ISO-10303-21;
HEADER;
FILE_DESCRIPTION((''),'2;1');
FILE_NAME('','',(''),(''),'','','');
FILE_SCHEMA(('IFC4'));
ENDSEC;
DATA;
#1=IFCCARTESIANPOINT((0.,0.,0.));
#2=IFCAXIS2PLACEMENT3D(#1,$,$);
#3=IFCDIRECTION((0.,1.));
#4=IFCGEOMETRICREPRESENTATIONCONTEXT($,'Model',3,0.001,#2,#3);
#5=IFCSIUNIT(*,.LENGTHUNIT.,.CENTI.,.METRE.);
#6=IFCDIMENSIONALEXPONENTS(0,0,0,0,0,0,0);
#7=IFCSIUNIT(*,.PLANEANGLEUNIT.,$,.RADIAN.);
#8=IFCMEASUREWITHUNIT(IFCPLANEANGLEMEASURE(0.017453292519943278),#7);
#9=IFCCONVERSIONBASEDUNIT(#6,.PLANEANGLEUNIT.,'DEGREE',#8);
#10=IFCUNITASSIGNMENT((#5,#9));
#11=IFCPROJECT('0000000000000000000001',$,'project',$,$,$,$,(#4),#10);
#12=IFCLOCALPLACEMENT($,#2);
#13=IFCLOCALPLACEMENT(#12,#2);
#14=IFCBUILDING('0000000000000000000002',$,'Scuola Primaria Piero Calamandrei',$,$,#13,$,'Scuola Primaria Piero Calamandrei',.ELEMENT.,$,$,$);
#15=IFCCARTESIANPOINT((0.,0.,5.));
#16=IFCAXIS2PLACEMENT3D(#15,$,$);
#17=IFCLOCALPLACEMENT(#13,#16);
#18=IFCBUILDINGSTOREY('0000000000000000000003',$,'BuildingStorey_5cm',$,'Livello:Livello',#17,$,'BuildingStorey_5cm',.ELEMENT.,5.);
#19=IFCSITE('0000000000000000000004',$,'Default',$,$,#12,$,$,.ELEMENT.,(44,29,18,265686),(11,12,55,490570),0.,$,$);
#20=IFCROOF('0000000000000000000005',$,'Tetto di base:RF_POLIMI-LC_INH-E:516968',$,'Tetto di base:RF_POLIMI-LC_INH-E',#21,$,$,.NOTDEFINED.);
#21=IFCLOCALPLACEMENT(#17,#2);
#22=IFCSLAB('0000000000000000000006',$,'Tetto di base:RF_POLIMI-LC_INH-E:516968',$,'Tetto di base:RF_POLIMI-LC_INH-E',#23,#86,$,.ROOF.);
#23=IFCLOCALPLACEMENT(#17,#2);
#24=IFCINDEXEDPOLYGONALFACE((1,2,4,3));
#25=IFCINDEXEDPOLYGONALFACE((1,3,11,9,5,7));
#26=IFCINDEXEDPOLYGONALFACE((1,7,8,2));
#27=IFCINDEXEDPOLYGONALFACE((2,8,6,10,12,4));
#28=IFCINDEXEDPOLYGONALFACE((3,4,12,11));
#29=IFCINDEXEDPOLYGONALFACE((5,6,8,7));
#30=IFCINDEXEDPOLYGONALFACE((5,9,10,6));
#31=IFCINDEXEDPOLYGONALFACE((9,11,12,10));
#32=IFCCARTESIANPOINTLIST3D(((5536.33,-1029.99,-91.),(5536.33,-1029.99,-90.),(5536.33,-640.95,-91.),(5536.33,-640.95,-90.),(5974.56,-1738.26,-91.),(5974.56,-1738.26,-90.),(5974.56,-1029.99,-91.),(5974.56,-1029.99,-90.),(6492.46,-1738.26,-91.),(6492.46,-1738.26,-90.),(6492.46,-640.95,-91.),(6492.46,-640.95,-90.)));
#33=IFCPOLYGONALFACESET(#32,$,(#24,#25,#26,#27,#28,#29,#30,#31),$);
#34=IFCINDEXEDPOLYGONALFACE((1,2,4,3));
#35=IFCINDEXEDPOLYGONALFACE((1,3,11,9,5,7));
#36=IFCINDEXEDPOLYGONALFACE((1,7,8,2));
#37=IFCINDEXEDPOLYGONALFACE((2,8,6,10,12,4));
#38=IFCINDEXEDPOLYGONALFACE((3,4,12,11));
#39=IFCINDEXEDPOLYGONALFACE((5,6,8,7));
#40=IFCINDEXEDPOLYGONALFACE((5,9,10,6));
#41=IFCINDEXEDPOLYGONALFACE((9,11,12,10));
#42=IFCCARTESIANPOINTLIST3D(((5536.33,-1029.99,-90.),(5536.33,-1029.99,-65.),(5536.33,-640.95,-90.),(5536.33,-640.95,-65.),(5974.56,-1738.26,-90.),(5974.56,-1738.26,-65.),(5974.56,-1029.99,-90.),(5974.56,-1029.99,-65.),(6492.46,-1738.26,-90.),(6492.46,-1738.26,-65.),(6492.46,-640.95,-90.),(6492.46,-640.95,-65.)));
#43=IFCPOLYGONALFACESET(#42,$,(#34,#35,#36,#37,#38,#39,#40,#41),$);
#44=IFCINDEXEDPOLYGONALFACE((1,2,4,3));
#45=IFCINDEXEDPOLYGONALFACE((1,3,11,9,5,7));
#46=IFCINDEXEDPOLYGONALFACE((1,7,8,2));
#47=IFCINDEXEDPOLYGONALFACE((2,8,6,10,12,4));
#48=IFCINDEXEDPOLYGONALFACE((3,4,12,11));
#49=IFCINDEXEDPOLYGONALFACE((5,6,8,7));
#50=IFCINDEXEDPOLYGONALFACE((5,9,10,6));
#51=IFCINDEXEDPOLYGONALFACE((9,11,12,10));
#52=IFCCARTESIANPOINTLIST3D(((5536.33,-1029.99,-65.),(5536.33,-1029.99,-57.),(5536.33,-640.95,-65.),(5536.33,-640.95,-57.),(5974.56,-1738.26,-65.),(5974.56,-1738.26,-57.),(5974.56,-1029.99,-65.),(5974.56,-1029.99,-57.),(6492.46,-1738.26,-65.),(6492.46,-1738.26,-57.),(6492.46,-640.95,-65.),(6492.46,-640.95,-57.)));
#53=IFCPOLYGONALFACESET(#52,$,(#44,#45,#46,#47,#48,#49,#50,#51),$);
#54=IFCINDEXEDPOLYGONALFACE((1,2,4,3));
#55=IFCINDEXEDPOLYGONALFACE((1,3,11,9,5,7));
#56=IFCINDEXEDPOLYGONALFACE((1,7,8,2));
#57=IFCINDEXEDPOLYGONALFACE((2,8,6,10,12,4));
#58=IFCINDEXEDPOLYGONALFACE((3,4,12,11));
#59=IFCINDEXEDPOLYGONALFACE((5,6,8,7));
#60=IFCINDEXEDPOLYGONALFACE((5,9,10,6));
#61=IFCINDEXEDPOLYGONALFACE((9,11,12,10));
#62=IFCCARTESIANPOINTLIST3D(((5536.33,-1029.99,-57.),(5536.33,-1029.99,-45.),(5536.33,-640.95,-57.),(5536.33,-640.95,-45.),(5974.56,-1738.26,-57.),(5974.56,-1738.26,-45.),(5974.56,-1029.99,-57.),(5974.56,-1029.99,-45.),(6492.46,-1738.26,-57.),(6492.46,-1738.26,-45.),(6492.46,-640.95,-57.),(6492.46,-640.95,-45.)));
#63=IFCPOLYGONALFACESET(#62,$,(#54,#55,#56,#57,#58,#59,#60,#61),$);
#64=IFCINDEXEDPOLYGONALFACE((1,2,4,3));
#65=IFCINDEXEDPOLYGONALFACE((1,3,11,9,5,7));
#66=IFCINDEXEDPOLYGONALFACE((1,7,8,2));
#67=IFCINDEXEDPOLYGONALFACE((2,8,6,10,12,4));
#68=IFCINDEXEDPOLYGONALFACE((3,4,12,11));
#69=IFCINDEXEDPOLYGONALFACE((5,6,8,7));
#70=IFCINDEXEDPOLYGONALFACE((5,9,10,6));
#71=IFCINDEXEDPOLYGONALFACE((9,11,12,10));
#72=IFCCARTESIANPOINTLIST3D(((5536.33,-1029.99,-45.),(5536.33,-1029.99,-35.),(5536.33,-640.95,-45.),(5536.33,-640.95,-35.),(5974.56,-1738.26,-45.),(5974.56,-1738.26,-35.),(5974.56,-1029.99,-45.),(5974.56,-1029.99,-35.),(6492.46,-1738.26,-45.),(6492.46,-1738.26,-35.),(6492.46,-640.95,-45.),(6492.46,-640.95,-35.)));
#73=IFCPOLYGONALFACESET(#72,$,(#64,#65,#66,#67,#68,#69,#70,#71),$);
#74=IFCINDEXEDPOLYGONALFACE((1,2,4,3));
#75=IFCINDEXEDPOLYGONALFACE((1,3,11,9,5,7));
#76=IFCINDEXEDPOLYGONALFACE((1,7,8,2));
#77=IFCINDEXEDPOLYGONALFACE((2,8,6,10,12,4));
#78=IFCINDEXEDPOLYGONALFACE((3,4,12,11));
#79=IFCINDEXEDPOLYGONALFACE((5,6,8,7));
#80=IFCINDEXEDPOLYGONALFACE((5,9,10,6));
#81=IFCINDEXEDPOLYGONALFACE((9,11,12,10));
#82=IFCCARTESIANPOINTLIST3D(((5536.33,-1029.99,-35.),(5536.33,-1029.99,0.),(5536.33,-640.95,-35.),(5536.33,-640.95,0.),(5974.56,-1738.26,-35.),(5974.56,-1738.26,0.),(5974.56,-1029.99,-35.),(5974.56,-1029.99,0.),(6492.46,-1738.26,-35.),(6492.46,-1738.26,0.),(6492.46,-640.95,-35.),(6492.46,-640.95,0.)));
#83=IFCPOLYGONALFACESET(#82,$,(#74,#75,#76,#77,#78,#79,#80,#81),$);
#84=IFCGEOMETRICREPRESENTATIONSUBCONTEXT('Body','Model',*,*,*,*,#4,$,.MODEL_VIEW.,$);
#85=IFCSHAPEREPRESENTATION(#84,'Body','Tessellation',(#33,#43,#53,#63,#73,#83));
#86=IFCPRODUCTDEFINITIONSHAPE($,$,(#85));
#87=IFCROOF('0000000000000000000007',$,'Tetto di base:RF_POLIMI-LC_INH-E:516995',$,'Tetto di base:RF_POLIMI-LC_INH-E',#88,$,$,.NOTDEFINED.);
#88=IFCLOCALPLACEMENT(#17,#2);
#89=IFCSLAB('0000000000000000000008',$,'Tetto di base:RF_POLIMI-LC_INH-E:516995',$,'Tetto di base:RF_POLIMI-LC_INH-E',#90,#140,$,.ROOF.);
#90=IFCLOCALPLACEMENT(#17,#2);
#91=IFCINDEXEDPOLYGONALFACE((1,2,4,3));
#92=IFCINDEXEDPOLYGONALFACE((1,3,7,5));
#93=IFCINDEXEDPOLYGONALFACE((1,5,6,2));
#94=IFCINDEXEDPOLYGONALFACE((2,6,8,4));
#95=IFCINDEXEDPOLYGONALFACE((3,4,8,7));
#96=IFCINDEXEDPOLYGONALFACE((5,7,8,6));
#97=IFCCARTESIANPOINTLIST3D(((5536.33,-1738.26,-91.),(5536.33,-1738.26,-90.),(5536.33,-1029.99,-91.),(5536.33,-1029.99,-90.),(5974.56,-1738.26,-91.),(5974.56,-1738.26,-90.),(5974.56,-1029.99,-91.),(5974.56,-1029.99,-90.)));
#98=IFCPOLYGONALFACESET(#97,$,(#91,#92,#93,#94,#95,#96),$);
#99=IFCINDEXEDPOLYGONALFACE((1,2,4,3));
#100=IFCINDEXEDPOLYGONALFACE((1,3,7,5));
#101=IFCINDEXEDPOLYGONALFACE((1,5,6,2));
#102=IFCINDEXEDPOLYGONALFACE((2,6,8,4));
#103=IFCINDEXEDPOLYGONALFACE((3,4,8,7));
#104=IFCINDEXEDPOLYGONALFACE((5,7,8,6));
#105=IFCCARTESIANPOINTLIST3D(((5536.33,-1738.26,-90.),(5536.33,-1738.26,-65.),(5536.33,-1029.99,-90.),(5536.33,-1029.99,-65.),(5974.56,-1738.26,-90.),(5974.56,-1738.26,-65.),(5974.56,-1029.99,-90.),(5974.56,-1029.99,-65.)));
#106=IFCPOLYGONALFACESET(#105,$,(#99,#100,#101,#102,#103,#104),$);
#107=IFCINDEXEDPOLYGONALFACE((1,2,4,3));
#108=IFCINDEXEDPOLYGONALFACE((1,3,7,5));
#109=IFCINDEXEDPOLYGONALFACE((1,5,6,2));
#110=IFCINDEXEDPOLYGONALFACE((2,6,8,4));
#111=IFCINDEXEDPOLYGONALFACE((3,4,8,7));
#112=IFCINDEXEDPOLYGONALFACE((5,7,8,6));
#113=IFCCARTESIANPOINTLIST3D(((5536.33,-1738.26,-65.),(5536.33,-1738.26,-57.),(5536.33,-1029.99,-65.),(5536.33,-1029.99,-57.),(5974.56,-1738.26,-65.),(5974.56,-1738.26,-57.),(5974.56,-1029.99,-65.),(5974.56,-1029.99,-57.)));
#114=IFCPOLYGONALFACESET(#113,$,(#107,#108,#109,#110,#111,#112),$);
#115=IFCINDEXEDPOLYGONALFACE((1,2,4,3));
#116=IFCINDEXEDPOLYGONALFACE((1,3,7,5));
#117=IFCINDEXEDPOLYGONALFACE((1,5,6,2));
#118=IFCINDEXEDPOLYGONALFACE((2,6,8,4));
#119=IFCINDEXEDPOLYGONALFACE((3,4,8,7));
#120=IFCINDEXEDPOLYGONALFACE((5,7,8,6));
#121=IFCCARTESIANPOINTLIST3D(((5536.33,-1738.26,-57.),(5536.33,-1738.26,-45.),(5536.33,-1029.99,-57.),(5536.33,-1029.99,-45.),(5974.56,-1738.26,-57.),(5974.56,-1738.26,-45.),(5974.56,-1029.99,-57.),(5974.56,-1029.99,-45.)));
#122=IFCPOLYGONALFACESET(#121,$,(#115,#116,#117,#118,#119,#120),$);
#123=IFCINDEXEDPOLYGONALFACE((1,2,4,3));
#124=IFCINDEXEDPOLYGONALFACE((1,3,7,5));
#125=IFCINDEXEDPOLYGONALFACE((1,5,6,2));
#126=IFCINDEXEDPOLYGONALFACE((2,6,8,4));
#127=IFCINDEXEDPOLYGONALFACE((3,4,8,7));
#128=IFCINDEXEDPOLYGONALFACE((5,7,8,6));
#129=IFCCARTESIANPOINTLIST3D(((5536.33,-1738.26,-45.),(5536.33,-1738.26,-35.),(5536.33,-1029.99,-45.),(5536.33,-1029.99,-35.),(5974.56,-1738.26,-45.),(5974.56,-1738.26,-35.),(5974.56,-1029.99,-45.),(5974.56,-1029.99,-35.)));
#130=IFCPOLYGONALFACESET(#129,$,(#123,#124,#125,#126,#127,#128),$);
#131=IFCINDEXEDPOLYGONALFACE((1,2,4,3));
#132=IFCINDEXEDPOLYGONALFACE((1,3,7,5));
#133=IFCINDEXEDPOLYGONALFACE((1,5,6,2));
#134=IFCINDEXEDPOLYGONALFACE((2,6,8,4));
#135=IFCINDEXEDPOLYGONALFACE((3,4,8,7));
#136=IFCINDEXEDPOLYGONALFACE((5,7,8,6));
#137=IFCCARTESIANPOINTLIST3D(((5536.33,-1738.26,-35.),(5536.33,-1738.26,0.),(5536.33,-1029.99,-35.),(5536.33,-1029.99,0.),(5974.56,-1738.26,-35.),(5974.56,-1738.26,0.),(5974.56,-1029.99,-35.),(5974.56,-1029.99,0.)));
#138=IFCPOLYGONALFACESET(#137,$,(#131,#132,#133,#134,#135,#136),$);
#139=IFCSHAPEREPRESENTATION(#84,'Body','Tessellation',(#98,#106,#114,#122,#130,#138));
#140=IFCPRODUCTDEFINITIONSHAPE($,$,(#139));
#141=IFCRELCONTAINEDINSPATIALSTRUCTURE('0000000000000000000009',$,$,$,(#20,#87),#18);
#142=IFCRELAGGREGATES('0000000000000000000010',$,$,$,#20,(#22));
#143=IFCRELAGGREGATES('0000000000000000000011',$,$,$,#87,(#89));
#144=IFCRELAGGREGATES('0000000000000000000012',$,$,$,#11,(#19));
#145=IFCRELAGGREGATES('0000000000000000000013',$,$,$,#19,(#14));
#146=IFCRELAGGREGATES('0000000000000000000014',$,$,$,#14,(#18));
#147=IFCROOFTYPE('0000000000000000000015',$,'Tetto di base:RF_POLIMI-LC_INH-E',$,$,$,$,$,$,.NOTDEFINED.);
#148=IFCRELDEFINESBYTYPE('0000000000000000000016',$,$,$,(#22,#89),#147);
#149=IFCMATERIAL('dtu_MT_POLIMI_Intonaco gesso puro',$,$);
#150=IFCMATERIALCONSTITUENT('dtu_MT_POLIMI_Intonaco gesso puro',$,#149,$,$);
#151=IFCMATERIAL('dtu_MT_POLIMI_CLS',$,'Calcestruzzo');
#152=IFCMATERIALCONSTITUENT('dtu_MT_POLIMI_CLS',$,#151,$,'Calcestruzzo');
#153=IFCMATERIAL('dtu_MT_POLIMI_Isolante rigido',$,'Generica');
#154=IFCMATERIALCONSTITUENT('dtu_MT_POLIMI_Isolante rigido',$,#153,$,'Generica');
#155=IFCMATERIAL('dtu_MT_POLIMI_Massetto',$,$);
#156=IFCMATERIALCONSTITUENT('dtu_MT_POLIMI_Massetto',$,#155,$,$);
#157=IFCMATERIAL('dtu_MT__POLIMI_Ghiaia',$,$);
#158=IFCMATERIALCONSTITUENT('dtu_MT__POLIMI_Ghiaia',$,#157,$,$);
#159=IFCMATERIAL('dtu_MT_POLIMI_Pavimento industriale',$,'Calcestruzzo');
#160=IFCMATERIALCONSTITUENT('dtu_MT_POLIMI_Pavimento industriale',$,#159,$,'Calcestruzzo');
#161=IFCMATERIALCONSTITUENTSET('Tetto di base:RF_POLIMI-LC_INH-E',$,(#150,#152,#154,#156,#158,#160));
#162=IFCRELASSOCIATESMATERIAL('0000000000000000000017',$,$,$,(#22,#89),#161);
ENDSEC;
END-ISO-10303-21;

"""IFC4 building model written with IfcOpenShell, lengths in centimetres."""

from ifc_helpers import new_model, entity, si_unit, converted_unit, direction, frame, origin, place, context, subcontext, project, spatial, indexed_curve, outline, extrude, material, constituent, constituent_set, type_object, element, aggregate, save


model = new_model("IFC4")

# Units and contexts
model_context = context("Model", 3, precision=0.001, world=origin(), true_north=direction((0.0, 1.0)))
body_context = subcontext(model_context, "Body", "Model", "MODEL_VIEW")
ifc_project = project(units=[si_unit("LENGTHUNIT", "METRE", prefix="CENTI"), converted_unit("PLANEANGLEUNIT", "DEGREE", entity("IfcPlaneAngleMeasure", 0.017453292519943278), si_unit("PLANEANGLEUNIT", "RADIAN"), dimensions=[0, 0, 0, 0, 0, 0, 0])], contexts=[model_context])

# Site, building, storey
site_placement = place(None, origin())
site = spatial("IfcSite", under=ifc_project, at=site_placement, Name="Default", CompositionType="ELEMENT", RefLatitude=(44, 29, 18, 265686), RefLongitude=(11, 12, 55, 490570), RefElevation=0.0)
building_placement = place(site_placement, origin())
building = spatial("IfcBuilding", under=site, at=building_placement, Name="Scuola Primaria Piero Calamandrei", LongName="Scuola Primaria Piero Calamandrei", CompositionType="ELEMENT")
storey_placement = place(building_placement, frame((0.0, 0.0, 5.0)))
storey = spatial("IfcBuildingStorey", under=building, at=storey_placement, Name="BuildingStorey_5cm", ObjectType="Livello:Livello", LongName="BuildingStorey_5cm", CompositionType="ELEMENT", Elevation=5.0)

# Roofs, slabs
ifc_material_1 = material(Name="dtu_MT_POLIMI_Intonaco gesso puro")
ifc_constituent_1 = constituent(ifc_material_1, Name="dtu_MT_POLIMI_Intonaco gesso puro")
ifc_material_2 = material(Name="dtu_MT_POLIMI_CLS", Category="Calcestruzzo")
ifc_constituent_2 = constituent(ifc_material_2, Name="dtu_MT_POLIMI_CLS", Category="Calcestruzzo")
ifc_material_3 = material(Name="dtu_MT_POLIMI_Isolante rigido", Category="Generica")
ifc_constituent_3 = constituent(ifc_material_3, Name="dtu_MT_POLIMI_Isolante rigido", Category="Generica")
ifc_material_4 = material(Name="dtu_MT_POLIMI_Massetto")
ifc_constituent_4 = constituent(ifc_material_4, Name="dtu_MT_POLIMI_Massetto")
ifc_material_5 = material(Name="dtu_MT__POLIMI_Ghiaia")
ifc_constituent_5 = constituent(ifc_material_5, Name="dtu_MT__POLIMI_Ghiaia")
ifc_material_6 = material(Name="dtu_MT_POLIMI_Pavimento industriale", Category="Calcestruzzo")
ifc_constituent_6 = constituent(ifc_material_6, Name="dtu_MT_POLIMI_Pavimento industriale", Category="Calcestruzzo")
ifc_constituent_set_1 = constituent_set(constituents=[ifc_constituent_1, ifc_constituent_2, ifc_constituent_3, ifc_constituent_4, ifc_constituent_5, ifc_constituent_6], Name="Tetto di base:RF_POLIMI-LC_INH-E")
roof_type = type_object("IfcRoofType", Name="Tetto di base:RF_POLIMI-LC_INH-E", PredefinedType="NOTDEFINED")
roof_1_placement = place(storey_placement, frame((5536.33, -1738.26, -91.0)))
roof_1 = element("IfcRoof", 1, at=roof_1_placement, inside=storey, Name="Tetto di base:RF_POLIMI-LC_INH-E:516968", ObjectType="Tetto di base:RF_POLIMI-LC_INH-E", PredefinedType="NOTDEFINED")
slab_1_placement = place(roof_1_placement, origin())
slab_1 = element("IfcSlab", 2, at=slab_1_placement, type_object=roof_type, material=ifc_constituent_set_1, Name="Tetto di base:RF_POLIMI-LC_INH-E:516968", ObjectType="Tetto di base:RF_POLIMI-LC_INH-E", PredefinedType="ROOF", context=body_context, shape_type="SweptSolid", body=[
    extrude(outline(indexed_curve([(478.06, 548.66), (-478.06, 548.66), (-478.06, 159.61), (-39.84, 159.61), (-39.84, -548.66), (478.06, -548.66), (478.06, 548.66)], self_intersect=False)), frame((478.06, 548.66, 0.0)), (0.0, 0.0, 1.0), 1.0),
    extrude(outline(indexed_curve([(478.06, 548.66), (-478.06, 548.66), (-478.06, 159.61), (-39.84, 159.61), (-39.84, -548.66), (478.06, -548.66), (478.06, 548.66)], self_intersect=False)), frame((478.06, 548.66, 1.0)), (0.0, 0.0, 1.0), 25.0),
    extrude(outline(indexed_curve([(478.06, 548.66), (-478.06, 548.66), (-478.06, 159.61), (-39.84, 159.61), (-39.84, -548.66), (478.06, -548.66), (478.06, 548.66)], self_intersect=False)), frame((478.06, 548.66, 26.0)), (0.0, 0.0, 1.0), 8.0),
    extrude(outline(indexed_curve([(478.06, 548.66), (-478.06, 548.66), (-478.06, 159.61), (-39.84, 159.61), (-39.84, -548.66), (478.06, -548.66), (478.06, 548.66)], self_intersect=False)), frame((478.06, 548.66, 34.0)), (0.0, 0.0, 1.0), 12.0),
    extrude(outline(indexed_curve([(478.06, 548.66), (-478.06, 548.66), (-478.06, 159.61), (-39.84, 159.61), (-39.84, -548.66), (478.06, -548.66), (478.06, 548.66)], self_intersect=False)), frame((478.06, 548.66, 46.0)), (0.0, 0.0, 1.0), 10.0),
    extrude(outline(indexed_curve([(478.06, 548.66), (-478.06, 548.66), (-478.06, 159.61), (-39.84, 159.61), (-39.84, -548.66), (478.06, -548.66), (478.06, 548.66)], self_intersect=False)), frame((478.06, 548.66, 56.0)), (0.0, 0.0, 1.0), 35.0),
])
aggregate(roof_1, [slab_1])
roof_2_placement = place(storey_placement, frame((5536.33, -1738.26, -91.0)))
roof_2 = element("IfcRoof", 3, at=roof_2_placement, inside=storey, Name="Tetto di base:RF_POLIMI-LC_INH-E:516995", ObjectType="Tetto di base:RF_POLIMI-LC_INH-E", PredefinedType="NOTDEFINED")
slab_2_placement = place(roof_2_placement, origin())
slab_2 = element("IfcSlab", 4, at=slab_2_placement, type_object=roof_type, material=ifc_constituent_set_1, Name="Tetto di base:RF_POLIMI-LC_INH-E:516995", ObjectType="Tetto di base:RF_POLIMI-LC_INH-E", PredefinedType="ROOF", context=body_context, shape_type="SweptSolid", body=[
    extrude(outline(indexed_curve([(219.11, 354.13), (-219.11, 354.13), (-219.11, -354.13), (219.11, -354.13), (219.11, 354.13)], self_intersect=False)), frame((219.11, 354.13, 0.0)), (0.0, 0.0, 1.0), 1.0),
    extrude(outline(indexed_curve([(219.11, 354.13), (-219.11, 354.13), (-219.11, -354.13), (219.11, -354.13), (219.11, 354.13)], self_intersect=False)), frame((219.11, 354.13, 1.0)), (0.0, 0.0, 1.0), 25.0),
    extrude(outline(indexed_curve([(219.11, 354.13), (-219.11, 354.13), (-219.11, -354.13), (219.11, -354.13), (219.11, 354.13)], self_intersect=False)), frame((219.11, 354.13, 26.0)), (0.0, 0.0, 1.0), 8.0),
    extrude(outline(indexed_curve([(219.11, 354.13), (-219.11, 354.13), (-219.11, -354.13), (219.11, -354.13), (219.11, 354.13)], self_intersect=False)), frame((219.11, 354.13, 34.0)), (0.0, 0.0, 1.0), 12.0),
    extrude(outline(indexed_curve([(219.11, 354.13), (-219.11, 354.13), (-219.11, -354.13), (219.11, -354.13), (219.11, 354.13)], self_intersect=False)), frame((219.11, 354.13, 46.0)), (0.0, 0.0, 1.0), 10.0),
    extrude(outline(indexed_curve([(219.11, 354.13), (-219.11, 354.13), (-219.11, -354.13), (219.11, -354.13), (219.11, 354.13)], self_intersect=False)), frame((219.11, 354.13, 56.0)), (0.0, 0.0, 1.0), 35.0),
])
aggregate(roof_2, [slab_2])

save(model, "model.ifc")
